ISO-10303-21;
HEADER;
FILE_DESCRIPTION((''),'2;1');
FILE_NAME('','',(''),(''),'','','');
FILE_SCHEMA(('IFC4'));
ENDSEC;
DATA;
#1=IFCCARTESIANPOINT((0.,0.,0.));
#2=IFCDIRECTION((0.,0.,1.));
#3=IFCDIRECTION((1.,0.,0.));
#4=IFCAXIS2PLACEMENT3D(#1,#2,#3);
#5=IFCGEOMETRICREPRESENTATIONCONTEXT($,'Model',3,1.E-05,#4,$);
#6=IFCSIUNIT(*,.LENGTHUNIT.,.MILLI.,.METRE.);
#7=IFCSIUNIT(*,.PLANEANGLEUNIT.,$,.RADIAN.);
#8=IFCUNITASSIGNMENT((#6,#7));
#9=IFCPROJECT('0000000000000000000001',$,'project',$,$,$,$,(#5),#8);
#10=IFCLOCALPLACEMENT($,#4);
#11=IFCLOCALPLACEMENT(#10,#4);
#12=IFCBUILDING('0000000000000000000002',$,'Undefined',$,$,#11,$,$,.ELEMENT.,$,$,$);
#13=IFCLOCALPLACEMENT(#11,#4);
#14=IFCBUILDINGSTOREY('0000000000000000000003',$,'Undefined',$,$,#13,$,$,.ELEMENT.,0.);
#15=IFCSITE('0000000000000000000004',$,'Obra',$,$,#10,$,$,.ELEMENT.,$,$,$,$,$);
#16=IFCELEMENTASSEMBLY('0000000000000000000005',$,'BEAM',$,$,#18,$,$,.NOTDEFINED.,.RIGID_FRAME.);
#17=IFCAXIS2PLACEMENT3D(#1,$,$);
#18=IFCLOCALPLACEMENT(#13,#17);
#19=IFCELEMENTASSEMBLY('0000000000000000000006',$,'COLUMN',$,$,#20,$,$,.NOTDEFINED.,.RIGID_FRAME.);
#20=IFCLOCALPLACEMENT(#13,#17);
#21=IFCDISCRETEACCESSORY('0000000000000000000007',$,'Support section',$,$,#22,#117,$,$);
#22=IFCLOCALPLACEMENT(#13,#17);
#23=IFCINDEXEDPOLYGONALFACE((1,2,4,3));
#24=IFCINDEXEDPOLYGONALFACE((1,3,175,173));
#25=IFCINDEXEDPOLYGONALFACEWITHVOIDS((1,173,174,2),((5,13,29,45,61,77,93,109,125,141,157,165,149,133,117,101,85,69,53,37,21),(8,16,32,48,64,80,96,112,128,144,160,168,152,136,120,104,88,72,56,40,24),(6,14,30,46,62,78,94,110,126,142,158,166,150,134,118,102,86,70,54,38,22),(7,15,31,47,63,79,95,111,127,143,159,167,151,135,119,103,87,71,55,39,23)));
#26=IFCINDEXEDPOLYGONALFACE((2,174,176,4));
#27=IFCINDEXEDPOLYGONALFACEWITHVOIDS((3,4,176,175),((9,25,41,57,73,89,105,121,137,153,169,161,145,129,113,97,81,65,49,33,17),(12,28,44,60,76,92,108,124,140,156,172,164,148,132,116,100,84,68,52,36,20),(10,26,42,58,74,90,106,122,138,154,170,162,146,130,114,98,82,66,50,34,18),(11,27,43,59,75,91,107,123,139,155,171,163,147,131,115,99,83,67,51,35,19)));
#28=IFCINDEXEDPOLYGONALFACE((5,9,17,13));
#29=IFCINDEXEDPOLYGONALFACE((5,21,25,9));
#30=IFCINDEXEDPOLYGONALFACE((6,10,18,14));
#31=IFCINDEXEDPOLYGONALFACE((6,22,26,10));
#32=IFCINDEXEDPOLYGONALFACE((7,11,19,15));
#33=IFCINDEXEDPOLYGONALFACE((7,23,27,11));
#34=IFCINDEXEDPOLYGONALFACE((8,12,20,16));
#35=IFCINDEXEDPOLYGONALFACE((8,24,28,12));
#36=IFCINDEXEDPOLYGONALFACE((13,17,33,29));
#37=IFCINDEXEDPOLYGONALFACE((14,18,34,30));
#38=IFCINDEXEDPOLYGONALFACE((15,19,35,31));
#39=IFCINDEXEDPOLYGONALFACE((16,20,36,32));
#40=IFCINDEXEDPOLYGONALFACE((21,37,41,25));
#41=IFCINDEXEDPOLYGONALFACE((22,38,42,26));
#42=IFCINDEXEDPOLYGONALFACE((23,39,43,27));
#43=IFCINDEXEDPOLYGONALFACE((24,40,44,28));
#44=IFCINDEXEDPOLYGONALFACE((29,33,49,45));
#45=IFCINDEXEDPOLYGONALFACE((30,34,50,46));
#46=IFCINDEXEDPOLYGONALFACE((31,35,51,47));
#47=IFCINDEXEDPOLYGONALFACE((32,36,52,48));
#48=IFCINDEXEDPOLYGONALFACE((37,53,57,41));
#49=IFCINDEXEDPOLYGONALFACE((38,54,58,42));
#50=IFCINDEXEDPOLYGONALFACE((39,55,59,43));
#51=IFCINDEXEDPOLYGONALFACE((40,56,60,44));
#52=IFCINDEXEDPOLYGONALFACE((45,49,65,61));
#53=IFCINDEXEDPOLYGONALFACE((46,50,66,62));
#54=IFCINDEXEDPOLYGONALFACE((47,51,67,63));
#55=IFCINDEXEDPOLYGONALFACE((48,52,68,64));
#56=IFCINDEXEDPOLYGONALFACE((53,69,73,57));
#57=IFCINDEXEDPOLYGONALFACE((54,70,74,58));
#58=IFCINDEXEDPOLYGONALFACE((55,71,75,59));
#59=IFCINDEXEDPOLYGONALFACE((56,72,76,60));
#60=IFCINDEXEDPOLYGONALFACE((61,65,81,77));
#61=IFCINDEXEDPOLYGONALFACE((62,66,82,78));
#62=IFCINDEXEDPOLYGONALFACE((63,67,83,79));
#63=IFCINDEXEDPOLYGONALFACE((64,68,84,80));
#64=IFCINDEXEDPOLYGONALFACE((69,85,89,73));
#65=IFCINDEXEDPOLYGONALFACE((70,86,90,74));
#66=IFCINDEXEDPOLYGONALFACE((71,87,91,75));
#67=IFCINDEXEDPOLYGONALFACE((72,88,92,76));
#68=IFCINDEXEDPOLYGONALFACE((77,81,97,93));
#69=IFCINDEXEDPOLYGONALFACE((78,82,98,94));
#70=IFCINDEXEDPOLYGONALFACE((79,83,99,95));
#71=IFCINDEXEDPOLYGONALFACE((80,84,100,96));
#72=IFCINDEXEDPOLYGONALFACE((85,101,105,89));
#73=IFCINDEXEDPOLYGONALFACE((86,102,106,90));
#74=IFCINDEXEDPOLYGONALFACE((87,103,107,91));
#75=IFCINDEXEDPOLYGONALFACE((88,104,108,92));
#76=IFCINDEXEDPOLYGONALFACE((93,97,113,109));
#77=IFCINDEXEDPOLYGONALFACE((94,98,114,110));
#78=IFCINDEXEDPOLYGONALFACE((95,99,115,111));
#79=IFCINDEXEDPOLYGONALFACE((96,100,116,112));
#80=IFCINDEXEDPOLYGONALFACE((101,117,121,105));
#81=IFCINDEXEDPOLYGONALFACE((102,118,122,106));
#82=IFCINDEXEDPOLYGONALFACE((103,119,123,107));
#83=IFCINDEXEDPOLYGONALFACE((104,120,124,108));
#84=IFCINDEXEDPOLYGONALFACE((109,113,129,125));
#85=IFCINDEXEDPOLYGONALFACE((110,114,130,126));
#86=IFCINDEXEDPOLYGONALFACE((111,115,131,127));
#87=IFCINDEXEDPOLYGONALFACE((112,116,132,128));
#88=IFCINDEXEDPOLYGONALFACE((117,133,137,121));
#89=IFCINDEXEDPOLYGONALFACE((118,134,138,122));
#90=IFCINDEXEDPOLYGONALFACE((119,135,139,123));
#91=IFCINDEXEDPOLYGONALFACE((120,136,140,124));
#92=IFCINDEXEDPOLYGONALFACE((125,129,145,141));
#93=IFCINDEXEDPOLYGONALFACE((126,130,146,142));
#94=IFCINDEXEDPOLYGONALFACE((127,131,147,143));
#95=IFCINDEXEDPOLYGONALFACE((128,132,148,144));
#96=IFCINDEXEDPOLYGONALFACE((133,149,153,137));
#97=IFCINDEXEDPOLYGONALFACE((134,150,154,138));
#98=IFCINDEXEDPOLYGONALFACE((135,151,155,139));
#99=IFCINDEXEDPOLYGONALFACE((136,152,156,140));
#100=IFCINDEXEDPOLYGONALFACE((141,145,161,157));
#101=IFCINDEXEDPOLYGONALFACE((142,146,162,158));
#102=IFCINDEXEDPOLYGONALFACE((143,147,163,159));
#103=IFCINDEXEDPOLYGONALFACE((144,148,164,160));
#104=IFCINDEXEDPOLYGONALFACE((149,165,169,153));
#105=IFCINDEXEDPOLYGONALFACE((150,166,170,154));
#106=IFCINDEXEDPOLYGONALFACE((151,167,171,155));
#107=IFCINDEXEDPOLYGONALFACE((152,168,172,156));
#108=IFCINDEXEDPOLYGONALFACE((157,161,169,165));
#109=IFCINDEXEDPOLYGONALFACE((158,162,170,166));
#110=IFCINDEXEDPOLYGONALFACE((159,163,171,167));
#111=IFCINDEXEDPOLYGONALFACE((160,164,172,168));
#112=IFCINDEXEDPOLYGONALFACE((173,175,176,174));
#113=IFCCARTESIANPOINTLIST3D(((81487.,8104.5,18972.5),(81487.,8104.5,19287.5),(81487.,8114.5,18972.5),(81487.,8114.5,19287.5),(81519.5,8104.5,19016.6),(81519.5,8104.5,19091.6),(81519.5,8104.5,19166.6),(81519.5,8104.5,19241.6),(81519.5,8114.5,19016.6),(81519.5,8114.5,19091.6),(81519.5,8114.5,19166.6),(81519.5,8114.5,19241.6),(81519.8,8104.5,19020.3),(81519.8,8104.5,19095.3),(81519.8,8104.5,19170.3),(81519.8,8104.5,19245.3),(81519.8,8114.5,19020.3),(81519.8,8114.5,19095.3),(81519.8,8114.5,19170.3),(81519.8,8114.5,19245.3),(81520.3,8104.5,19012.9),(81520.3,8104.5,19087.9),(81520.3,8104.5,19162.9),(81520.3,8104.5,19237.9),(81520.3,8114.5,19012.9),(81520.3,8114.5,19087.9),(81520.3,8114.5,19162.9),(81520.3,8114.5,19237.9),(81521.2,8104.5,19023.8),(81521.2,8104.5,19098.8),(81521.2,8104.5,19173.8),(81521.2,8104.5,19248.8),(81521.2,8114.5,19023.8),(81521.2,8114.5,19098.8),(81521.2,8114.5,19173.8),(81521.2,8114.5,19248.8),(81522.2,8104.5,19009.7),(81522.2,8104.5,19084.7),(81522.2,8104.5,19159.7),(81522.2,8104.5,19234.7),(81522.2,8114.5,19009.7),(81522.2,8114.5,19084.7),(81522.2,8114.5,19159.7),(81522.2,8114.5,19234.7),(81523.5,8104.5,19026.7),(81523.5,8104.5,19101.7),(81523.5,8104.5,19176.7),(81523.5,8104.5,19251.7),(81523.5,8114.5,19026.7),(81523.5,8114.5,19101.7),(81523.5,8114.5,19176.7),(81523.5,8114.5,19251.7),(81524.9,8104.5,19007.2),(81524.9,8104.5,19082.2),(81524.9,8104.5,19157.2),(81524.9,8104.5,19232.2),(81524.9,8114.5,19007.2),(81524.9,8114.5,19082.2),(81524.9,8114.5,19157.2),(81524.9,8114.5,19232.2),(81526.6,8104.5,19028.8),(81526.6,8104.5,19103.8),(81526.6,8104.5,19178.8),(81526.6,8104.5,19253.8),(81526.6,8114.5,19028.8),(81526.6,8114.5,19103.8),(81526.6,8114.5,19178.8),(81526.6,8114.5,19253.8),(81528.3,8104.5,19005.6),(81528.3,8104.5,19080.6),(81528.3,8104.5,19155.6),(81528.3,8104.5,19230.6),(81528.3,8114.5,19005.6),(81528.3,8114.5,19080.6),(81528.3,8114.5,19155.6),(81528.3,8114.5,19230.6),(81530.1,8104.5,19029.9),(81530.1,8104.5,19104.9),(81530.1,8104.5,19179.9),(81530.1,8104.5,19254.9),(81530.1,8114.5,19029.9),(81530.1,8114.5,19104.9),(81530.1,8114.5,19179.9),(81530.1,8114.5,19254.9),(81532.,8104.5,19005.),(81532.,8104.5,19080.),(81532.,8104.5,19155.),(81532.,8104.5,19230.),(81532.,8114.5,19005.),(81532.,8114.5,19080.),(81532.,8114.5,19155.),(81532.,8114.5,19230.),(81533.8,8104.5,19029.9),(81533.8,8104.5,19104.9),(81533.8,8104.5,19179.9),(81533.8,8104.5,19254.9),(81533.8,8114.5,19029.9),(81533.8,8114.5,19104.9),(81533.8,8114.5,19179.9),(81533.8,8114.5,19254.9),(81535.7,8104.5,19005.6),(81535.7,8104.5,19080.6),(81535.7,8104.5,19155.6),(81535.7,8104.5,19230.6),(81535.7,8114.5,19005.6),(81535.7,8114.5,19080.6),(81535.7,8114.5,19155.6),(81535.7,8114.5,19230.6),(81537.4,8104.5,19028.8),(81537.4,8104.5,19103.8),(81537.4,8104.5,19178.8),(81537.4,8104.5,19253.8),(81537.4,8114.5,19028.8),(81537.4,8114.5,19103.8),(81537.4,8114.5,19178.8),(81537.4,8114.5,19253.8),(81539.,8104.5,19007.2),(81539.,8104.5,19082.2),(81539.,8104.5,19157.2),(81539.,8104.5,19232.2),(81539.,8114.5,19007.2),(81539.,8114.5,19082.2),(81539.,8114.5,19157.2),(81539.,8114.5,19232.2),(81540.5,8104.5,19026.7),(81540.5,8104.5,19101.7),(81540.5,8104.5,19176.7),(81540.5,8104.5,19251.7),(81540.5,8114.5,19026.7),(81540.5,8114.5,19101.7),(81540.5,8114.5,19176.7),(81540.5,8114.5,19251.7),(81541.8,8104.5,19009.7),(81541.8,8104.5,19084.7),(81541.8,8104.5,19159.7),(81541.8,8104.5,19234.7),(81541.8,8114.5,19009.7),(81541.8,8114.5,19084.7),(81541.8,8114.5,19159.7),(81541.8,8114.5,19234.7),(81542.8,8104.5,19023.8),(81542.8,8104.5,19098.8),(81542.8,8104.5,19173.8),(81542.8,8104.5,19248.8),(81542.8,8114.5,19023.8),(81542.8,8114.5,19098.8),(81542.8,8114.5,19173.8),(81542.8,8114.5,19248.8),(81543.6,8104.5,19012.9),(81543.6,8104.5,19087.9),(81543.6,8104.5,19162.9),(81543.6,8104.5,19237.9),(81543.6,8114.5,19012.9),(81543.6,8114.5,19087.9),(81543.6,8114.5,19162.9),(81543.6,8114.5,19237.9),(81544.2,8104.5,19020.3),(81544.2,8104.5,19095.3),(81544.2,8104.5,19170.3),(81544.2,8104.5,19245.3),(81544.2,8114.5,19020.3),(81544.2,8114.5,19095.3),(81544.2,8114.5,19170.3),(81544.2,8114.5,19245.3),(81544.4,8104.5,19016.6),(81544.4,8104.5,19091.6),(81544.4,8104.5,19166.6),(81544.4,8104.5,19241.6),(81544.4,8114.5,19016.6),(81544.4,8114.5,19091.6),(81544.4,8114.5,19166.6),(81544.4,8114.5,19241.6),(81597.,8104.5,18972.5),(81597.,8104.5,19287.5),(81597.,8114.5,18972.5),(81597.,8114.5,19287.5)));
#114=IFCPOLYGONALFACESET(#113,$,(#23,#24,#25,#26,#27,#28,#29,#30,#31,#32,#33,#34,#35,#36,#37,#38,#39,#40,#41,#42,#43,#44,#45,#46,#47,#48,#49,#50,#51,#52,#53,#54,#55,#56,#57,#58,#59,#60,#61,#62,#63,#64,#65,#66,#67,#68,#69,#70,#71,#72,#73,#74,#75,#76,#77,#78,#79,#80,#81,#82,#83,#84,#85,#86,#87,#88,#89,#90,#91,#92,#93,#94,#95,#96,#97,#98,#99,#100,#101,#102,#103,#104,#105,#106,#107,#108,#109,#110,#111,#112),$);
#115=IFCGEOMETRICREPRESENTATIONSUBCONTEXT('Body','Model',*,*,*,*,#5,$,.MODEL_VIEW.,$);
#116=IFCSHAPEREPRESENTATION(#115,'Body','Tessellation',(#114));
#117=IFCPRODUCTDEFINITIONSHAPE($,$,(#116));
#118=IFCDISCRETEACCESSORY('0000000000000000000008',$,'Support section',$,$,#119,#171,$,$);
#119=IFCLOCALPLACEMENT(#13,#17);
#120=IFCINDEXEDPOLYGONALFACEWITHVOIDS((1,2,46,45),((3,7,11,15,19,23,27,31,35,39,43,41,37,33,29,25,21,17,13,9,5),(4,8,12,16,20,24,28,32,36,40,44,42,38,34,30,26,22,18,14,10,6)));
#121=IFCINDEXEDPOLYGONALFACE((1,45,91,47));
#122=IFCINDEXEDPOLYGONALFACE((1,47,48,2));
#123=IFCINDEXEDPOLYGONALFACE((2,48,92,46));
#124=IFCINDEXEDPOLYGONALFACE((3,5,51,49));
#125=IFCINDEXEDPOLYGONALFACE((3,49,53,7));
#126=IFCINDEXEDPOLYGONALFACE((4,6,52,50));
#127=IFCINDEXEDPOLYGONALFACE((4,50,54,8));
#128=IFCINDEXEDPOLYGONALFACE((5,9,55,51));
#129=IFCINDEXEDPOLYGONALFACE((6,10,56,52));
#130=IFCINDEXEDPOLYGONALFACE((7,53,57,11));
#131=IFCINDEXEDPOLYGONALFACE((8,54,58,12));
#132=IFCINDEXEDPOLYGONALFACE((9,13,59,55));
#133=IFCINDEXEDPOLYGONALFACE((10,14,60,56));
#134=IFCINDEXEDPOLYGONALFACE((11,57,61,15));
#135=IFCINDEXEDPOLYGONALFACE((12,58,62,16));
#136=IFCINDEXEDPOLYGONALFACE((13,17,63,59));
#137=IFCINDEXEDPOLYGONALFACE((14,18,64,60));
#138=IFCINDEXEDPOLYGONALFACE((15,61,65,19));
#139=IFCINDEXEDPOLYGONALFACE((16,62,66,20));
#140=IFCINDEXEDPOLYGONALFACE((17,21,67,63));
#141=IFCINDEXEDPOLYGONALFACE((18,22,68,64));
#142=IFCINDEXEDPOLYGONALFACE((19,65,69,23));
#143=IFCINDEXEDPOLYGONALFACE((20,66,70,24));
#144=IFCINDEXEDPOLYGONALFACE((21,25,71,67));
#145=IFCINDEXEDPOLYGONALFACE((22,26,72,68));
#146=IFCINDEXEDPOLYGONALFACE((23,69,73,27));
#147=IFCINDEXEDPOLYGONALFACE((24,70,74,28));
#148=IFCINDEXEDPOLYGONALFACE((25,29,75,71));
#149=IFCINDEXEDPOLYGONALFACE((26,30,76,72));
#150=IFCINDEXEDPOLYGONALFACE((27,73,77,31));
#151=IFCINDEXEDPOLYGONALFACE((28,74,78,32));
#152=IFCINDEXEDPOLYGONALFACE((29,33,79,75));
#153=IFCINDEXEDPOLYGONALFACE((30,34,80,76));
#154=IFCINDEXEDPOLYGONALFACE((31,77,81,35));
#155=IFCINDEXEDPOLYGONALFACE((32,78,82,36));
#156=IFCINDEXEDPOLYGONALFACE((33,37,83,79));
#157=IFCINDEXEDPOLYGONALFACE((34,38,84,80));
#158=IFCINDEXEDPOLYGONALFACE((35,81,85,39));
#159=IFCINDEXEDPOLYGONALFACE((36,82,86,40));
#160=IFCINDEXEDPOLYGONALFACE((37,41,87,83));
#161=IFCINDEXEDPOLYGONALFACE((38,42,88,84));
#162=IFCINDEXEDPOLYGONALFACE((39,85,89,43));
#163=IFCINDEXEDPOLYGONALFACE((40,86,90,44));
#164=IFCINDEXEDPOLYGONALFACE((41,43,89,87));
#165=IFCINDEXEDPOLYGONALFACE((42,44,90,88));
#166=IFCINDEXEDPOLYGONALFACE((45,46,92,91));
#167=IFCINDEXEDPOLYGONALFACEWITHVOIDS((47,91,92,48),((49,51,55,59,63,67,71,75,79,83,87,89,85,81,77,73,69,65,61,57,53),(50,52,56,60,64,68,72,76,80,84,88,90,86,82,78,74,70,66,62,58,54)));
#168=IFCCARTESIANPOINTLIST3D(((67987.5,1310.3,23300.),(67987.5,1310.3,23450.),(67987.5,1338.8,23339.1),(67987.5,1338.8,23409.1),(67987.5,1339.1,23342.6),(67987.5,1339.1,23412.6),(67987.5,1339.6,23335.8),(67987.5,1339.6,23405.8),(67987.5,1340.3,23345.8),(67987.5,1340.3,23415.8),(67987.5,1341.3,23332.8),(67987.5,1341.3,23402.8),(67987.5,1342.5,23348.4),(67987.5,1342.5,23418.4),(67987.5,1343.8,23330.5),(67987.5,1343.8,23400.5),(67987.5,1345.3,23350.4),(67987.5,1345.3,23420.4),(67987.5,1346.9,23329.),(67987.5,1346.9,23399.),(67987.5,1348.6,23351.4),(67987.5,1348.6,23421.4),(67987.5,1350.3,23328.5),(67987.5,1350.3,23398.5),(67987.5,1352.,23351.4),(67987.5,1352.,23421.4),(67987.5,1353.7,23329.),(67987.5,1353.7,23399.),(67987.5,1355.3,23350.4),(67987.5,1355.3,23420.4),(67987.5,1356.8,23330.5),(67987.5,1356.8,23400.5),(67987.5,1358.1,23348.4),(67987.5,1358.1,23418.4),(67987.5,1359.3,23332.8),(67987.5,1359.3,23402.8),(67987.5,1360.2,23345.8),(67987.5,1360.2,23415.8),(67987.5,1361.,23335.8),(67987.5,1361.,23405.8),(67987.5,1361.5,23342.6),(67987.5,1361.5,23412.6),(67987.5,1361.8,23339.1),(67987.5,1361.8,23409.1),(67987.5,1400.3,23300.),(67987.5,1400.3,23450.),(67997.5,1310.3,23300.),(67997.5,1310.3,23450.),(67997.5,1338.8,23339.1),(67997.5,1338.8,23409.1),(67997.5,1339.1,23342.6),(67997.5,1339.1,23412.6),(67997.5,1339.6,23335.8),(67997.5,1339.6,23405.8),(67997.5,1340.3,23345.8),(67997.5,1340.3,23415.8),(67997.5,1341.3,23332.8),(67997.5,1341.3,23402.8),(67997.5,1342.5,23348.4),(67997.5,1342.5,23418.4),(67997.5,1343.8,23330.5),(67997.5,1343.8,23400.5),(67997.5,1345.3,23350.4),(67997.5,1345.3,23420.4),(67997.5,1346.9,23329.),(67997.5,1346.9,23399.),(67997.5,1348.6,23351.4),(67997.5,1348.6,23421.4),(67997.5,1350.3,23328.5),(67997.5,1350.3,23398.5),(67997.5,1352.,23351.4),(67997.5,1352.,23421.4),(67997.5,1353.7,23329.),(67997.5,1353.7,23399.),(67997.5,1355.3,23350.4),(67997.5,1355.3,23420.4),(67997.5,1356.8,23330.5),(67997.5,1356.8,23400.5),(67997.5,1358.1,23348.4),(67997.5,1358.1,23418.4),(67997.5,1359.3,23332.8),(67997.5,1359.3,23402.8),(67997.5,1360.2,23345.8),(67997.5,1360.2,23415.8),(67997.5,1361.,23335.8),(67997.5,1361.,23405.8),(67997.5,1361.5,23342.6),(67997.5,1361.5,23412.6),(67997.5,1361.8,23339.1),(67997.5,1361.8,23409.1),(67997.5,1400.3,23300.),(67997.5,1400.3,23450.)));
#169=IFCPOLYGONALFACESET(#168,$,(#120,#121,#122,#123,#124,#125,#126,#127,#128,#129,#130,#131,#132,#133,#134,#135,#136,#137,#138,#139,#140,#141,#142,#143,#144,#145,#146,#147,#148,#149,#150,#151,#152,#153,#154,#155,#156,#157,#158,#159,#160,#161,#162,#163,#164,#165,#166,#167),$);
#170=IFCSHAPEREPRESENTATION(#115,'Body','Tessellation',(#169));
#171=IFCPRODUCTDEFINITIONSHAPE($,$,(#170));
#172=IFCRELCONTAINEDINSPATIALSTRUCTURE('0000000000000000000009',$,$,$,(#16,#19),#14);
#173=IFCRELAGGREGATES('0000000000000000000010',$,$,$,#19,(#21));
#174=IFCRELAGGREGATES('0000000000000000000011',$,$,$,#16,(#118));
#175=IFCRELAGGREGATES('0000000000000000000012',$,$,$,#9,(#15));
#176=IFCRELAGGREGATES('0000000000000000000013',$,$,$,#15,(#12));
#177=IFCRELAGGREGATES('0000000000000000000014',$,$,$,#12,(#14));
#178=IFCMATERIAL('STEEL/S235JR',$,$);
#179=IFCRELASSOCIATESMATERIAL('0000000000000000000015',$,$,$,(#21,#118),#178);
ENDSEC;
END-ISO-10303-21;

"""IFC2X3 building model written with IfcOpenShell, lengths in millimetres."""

from ifc_helpers import new_model, si_unit, frame, origin_with_axes, origin_2d_with_axis, place, context, subcontext, project, spatial, rectangle, circle, extrude, source, transform, mapped, material, element, aggregate, save


model = new_model("IFC2X3")

# Units and contexts
model_context = context("Model", 3, precision=1e-05, world=origin_with_axes())
body_context = subcontext(model_context, "Body", "Model", "MODEL_VIEW")
ifc_project = project(units=[si_unit("LENGTHUNIT", "METRE", prefix="MILLI"), si_unit("PLANEANGLEUNIT", "RADIAN")], contexts=[model_context])

# Site, building, storey
site_placement = place(None, origin_with_axes())
site = spatial("IfcSite", under=ifc_project, at=site_placement, Name="Obra", CompositionType="ELEMENT")
building_placement = place(site_placement, origin_with_axes())
building = spatial("IfcBuilding", under=site, at=building_placement, Name="Undefined", CompositionType="ELEMENT")
storey_placement = place(building_placement, origin_with_axes())
storey = spatial("IfcBuildingStorey", under=building, at=storey_placement, Name="Undefined", CompositionType="ELEMENT", Elevation=0.0)

# Element assembly
assembly_1_placement = place(storey_placement, origin_with_axes())
assembly_1 = element("IfcElementAssembly", 1, at=assembly_1_placement, inside=storey, Name="BEAM", AssemblyPlace="NOTDEFINED", PredefinedType="RIGID_FRAME")

# Element assembly, discrete accessory, opening
assembly_2_placement = place(storey_placement, origin_with_axes())
assembly_2 = element("IfcElementAssembly", 2, at=assembly_2_placement, inside=storey, Name="COLUMN", AssemblyPlace="NOTDEFINED", PredefinedType="RIGID_FRAME")
ifc_material_1 = material(Name="STEEL/S235JR")
discrete_accessory_1_placement = place(assembly_2_placement, frame((81542.0, 8109.5, 18972.5), z_axis=(0.0, 0.0, 1.0), x_axis=(1.0, 0.0, 0.0)))
discrete_accessory_1 = element("IfcDiscreteAccessory", 3, at=discrete_accessory_1_placement, material=ifc_material_1, Name="Support section", context=body_context, shape_type="SweptSolid", body=[
    extrude(rectangle(XDim=10.0, YDim=110.0, at=origin_2d_with_axis()), frame((0.0, 0.0, 315.0), z_axis=(0.0, 0.0, -1.0), x_axis=(0.0, 1.0, 0.0)), (0.0, 0.0, 1.0), 315.0),
])
shared_shape_1 = source(origin_with_axes(), body_context, "Body", "SweptSolid", [
    extrude(circle(Radius=12.5, at=origin_2d_with_axis()), frame((0.0, 5.7, 0.0), z_axis=(0.0, 1.0, 0.0), x_axis=(1.0, 0.0, 0.0)), (0.0, 0.0, 1.0), 10.2),
])
opening_1_placement = place(assembly_2_placement, frame((81577.0, 8120.2, 19350.0), z_axis=(-1.0, 0.0, 0.0), x_axis=(0.0, 0.0, -1.0)))
element("IfcOpeningElement", 4, at=opening_1_placement, cuts=discrete_accessory_1, ObjectType="Opening", context=body_context, shape_type="MappedRepresentation", body=[
    mapped(shared_shape_1, transform((107.5, 0.0, 45.0))),
    mapped(shared_shape_1, transform((182.5, 0.0, 45.0))),
    mapped(shared_shape_1, transform((257.5, 0.0, 45.0))),
    mapped(shared_shape_1, transform((332.5, 0.0, 45.0))),
])
aggregate(assembly_2, [discrete_accessory_1])

# Discrete accessory, opening
discrete_accessory_2_placement = place(assembly_1_placement, frame((67992.5, 1355.3, 23300.0), z_axis=(0.0, 0.0, 1.0), x_axis=(0.0, 1.0, 0.0)))
discrete_accessory_2 = element("IfcDiscreteAccessory", 5, at=discrete_accessory_2_placement, material=ifc_material_1, Name="Support section", context=body_context, shape_type="SweptSolid", body=[
    extrude(rectangle(XDim=10.0, YDim=90.0, at=origin_2d_with_axis()), frame((0.0, 0.0, 150.0), z_axis=(0.0, 0.0, -1.0), x_axis=(0.0, 1.0, 0.0)), (0.0, 0.0, 1.0), 150.0),
])
shared_shape_2 = source(origin_with_axes(), body_context, "Body", "SweptSolid", [
    extrude(circle(Radius=11.5, at=origin_2d_with_axis()), frame((0.0, -12.6, 0.0), z_axis=(0.0, 1.0, 0.0), x_axis=(1.0, 0.0, 0.0)), (0.0, 0.0, 1.0), 10.2),
])
opening_2_placement = place(assembly_1_placement, frame((68000.0, 1390.3, 23455.0), z_axis=(0.0, -1.0, 0.0), x_axis=(0.0, 0.0, -1.0)))
element("IfcOpeningElement", 6, at=opening_2_placement, cuts=discrete_accessory_2, ObjectType="Opening", context=body_context, shape_type="MappedRepresentation", body=[
    mapped(shared_shape_2, transform((45.0, 0.0, 40.0))),
    mapped(shared_shape_2, transform((115.0, 0.0, 40.0))),
])

aggregate(assembly_1, [discrete_accessory_2])

save(model, "model.ifc")
